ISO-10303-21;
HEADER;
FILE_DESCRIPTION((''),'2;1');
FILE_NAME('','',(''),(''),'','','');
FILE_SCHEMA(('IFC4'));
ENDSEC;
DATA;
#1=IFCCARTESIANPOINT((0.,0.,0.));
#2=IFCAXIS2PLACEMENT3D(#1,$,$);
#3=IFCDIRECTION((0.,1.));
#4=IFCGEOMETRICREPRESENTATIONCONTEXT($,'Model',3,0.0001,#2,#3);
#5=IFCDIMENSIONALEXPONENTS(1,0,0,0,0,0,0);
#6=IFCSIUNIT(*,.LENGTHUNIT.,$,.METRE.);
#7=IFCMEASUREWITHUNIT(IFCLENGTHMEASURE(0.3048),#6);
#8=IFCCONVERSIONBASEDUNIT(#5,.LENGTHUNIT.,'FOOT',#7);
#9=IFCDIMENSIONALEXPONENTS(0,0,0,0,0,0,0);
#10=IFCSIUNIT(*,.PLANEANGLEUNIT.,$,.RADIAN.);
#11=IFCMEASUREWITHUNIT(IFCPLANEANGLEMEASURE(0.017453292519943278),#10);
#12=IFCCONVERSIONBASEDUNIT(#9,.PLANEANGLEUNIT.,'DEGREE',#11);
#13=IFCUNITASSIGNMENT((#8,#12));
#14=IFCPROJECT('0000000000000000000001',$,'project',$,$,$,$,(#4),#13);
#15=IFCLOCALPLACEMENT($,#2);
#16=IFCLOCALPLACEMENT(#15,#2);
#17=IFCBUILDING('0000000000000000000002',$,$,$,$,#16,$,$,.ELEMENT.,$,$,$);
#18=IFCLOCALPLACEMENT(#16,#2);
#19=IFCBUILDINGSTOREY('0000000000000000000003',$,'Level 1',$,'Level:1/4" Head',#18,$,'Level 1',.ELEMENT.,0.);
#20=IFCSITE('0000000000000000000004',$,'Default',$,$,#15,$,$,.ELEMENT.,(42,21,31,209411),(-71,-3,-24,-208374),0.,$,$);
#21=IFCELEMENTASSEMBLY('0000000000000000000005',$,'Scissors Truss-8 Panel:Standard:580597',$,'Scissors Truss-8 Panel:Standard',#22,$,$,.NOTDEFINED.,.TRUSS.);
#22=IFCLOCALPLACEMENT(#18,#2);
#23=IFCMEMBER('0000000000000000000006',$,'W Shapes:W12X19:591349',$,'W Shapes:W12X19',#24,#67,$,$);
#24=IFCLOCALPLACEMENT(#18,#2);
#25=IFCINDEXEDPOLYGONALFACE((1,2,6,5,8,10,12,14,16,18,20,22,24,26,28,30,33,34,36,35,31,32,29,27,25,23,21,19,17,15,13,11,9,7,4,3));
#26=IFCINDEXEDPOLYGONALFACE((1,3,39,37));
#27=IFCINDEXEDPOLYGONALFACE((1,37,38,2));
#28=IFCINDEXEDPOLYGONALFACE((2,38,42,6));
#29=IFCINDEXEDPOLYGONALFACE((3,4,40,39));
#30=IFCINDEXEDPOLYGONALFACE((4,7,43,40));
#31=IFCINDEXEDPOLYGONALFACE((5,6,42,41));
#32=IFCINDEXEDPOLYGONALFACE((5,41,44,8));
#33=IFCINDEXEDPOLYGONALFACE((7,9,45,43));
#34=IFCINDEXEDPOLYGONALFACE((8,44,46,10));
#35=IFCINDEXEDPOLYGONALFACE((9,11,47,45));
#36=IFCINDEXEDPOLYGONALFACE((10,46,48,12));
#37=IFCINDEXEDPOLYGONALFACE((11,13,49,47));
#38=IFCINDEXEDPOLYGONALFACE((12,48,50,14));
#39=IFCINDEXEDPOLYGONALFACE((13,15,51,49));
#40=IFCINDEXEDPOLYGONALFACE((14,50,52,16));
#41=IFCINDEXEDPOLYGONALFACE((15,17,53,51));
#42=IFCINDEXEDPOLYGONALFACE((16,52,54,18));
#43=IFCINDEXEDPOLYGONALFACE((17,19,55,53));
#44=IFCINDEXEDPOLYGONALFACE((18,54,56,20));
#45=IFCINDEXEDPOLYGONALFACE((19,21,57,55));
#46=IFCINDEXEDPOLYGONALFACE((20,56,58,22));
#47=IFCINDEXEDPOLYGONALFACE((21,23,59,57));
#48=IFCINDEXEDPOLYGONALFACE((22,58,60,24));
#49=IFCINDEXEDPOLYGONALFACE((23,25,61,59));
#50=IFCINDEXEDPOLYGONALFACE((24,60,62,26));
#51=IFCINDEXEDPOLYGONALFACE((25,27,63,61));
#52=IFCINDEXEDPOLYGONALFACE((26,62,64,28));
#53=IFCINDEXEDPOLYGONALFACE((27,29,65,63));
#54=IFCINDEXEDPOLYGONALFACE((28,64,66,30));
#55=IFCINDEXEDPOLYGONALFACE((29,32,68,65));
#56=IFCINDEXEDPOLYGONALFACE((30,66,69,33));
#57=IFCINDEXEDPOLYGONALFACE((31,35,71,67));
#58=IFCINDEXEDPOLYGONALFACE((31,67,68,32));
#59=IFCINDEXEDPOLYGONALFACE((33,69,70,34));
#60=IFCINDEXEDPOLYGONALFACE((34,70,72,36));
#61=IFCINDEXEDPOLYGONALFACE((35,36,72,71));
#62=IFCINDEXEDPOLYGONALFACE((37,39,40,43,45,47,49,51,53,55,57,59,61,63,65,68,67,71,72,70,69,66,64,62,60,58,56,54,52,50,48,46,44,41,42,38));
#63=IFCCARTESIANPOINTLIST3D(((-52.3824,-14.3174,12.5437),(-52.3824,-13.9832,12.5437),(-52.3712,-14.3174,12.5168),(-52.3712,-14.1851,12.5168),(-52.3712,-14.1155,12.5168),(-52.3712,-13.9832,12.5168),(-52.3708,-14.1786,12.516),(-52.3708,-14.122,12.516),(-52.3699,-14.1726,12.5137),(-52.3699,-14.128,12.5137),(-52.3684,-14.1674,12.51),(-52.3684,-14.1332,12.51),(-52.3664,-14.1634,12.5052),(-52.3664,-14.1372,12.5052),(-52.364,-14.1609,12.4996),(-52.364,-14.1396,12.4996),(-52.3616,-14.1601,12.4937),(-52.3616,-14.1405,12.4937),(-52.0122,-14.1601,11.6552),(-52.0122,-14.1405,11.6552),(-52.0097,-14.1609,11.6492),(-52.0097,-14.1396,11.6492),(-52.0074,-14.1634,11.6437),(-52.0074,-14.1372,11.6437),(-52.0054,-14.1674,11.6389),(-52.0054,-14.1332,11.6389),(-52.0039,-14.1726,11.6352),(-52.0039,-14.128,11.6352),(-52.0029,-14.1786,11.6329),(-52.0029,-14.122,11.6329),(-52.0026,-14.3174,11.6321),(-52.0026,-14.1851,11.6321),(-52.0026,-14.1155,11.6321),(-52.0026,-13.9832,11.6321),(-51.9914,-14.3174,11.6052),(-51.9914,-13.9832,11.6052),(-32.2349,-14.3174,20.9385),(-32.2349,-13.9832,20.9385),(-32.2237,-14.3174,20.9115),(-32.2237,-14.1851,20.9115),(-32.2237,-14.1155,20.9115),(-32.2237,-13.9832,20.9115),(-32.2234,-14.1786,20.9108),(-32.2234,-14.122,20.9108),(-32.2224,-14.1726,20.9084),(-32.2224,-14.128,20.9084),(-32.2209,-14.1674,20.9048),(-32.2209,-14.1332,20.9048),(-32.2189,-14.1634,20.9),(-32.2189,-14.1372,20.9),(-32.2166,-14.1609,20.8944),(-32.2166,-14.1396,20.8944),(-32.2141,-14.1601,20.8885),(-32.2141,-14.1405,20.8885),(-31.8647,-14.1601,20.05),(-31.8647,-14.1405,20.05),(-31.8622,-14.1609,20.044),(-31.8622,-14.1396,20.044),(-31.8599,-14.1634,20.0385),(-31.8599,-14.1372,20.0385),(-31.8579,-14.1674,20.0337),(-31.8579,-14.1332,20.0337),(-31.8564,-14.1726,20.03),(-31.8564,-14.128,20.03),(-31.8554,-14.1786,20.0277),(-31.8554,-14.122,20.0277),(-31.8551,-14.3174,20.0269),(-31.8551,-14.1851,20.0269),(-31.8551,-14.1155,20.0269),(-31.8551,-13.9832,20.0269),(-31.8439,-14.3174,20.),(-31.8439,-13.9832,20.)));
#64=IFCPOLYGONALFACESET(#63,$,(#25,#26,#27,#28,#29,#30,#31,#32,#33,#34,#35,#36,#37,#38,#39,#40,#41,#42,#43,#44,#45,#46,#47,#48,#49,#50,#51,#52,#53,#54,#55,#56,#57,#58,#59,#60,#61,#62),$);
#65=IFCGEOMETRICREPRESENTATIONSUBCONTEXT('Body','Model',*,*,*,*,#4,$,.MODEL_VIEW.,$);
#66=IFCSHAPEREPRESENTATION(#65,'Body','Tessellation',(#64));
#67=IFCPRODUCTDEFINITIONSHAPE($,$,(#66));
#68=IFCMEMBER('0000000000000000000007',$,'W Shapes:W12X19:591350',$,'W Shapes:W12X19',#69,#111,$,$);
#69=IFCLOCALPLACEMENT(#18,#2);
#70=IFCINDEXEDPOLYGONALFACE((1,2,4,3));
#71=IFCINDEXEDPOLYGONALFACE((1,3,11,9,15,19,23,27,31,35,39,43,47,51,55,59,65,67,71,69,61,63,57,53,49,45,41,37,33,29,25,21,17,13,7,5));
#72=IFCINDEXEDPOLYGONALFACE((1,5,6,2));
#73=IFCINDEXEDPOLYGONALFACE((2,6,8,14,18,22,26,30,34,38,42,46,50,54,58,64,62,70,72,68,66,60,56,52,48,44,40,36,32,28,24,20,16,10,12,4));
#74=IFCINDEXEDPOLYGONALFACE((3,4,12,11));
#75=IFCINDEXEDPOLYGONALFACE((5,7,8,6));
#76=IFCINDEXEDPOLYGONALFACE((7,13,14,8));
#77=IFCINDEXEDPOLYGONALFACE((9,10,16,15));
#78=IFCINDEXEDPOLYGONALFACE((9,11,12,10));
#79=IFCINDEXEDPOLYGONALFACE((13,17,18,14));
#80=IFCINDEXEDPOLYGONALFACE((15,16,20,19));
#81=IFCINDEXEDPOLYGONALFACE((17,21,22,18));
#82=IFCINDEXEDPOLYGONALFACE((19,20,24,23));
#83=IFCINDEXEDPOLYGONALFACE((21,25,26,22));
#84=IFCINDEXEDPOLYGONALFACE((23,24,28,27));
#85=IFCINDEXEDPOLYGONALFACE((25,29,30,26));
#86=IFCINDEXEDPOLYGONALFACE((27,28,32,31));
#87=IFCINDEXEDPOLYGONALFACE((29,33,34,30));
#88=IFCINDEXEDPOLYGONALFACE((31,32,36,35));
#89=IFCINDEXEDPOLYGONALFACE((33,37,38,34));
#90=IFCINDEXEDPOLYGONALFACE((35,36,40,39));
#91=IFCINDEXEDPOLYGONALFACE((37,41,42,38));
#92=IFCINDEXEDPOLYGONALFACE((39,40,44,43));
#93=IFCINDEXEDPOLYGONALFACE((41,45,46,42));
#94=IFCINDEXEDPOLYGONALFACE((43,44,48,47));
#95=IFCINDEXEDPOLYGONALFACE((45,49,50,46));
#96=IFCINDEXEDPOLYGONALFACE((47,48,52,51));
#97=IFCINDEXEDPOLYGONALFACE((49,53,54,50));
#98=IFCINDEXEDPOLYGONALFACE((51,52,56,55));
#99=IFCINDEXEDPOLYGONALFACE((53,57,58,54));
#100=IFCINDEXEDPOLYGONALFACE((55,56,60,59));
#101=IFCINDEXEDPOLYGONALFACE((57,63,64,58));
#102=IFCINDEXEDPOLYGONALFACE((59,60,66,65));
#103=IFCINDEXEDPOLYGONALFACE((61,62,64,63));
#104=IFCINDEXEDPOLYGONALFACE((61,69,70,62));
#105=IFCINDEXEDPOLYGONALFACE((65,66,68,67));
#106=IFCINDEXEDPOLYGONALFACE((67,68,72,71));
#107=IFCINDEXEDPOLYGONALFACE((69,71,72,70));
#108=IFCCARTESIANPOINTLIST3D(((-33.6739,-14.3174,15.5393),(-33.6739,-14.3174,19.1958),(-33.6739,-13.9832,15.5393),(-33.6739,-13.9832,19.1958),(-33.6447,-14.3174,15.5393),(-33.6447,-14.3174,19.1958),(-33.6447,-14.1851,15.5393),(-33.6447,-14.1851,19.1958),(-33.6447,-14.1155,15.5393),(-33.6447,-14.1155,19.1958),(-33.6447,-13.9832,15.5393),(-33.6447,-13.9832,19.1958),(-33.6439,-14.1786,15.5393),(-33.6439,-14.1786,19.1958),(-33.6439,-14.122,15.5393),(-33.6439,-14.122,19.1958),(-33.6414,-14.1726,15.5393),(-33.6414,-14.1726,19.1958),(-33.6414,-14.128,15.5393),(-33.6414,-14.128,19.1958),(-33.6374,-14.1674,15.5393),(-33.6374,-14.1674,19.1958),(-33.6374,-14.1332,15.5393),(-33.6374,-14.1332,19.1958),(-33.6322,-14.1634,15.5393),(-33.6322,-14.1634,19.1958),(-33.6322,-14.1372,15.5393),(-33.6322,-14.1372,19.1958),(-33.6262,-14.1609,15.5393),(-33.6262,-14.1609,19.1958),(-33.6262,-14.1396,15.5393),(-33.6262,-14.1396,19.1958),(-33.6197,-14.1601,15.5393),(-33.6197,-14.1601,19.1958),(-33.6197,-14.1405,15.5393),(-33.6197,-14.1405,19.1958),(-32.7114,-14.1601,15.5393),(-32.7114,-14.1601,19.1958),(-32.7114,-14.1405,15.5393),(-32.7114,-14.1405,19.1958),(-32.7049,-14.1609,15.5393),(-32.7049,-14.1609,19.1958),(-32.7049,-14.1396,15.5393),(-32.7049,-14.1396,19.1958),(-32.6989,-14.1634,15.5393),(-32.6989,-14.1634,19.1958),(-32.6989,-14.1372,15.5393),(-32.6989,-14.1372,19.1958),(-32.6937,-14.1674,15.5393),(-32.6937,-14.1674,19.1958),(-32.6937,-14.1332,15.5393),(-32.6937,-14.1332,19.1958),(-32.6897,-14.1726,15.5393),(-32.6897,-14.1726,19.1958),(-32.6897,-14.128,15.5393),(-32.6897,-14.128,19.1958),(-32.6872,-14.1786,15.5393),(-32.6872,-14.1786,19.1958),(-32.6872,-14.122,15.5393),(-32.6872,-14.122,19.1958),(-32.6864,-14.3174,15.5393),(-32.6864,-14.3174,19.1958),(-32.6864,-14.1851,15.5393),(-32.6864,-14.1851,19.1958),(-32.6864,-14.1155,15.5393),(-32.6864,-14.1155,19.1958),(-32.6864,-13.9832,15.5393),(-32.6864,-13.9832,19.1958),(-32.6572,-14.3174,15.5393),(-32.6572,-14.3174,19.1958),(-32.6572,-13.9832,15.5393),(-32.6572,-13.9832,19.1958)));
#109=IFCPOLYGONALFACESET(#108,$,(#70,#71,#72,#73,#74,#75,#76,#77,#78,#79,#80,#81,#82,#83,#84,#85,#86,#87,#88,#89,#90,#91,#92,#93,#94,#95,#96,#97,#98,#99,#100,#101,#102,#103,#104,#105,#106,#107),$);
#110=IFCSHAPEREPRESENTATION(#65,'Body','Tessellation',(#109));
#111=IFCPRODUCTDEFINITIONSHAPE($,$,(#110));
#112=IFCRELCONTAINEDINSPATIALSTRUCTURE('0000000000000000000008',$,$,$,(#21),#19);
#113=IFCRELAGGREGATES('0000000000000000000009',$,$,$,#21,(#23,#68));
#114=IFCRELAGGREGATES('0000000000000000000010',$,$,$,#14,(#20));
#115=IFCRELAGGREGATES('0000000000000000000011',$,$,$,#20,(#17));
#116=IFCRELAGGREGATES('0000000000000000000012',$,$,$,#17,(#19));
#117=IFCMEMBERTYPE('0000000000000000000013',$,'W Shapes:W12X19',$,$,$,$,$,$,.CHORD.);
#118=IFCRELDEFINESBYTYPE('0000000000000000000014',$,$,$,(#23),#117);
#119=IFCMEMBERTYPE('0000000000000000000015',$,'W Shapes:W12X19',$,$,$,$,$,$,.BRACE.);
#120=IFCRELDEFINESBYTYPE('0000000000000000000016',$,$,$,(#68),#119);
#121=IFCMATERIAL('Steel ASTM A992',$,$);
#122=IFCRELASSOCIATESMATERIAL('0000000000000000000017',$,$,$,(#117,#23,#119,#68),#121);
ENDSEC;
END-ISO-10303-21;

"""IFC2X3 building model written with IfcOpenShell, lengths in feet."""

from ifc_helpers import new_model, entity, si_unit, converted_unit, direction, frame, frame_2d, origin, place, context, subcontext, project, spatial, polyline, circle_curve, parameter, trimmed, segment, composite_curve, outline, extrude, source, transform, mapped, material, type_object, type_shapes, element, aggregate, save


model = new_model("IFC2X3")

# Units and contexts
model_context = context("Model", 3, precision=0.0001, world=origin(), true_north=direction((0.0, 1.0)))
body_context = subcontext(model_context, "Body", "Model", "MODEL_VIEW")
ifc_project = project(units=[converted_unit("LENGTHUNIT", "FOOT", entity("IfcLengthMeasure", 0.3048), si_unit("LENGTHUNIT", "METRE"), dimensions=[1, 0, 0, 0, 0, 0, 0]), converted_unit("PLANEANGLEUNIT", "DEGREE", entity("IfcPlaneAngleMeasure", 0.017453292519943278), si_unit("PLANEANGLEUNIT", "RADIAN"), dimensions=[0, 0, 0, 0, 0, 0, 0])], contexts=[model_context])

# Site, building, storey
site_placement = place(None, origin())
site = spatial("IfcSite", under=ifc_project, at=site_placement, Name="Default", CompositionType="ELEMENT", RefLatitude=(42, 21, 31, 209411), RefLongitude=(-71, -3, -24, -208374), RefElevation=0.0)
building_placement = place(site_placement, origin())
building = spatial("IfcBuilding", under=site, at=building_placement, CompositionType="ELEMENT")
storey_placement = place(building_placement, origin())
storey = spatial("IfcBuildingStorey", under=building, at=storey_placement, Name="Level 1", ObjectType="Level:1/4\" Head", LongName="Level 1", CompositionType="ELEMENT", Elevation=0.0)

# Element assembly, members
assembly_placement = place(storey_placement, origin())
assembly = element("IfcElementAssembly", 1, at=assembly_placement, inside=storey, Name="Scissors Truss-8 Panel:Standard:580597", ObjectType="Scissors Truss-8 Panel:Standard", AssemblyPlace="NOTDEFINED", PredefinedType="TRUSS")
ifc_material = material(Name="Steel ASTM A992")
member_type_1 = type_object("IfcMemberType", Name="W Shapes:W12X19", PredefinedType="CHORD", material=ifc_material)
shared_shape_1 = source(origin(), body_context, "Body", "SweptSolid", [
    extrude(outline(composite_curve([segment(polyline([(-0.1671, -0.4792), (-0.1671, -0.5083)]), True, "CONTINUOUS"), segment(polyline([(-0.1671, -0.5083), (0.1671, -0.5083)]), True, "CONTINUOUS"), segment(polyline([(0.1671, -0.5083), (0.1671, -0.4792)]), True, "CONTINUOUS"), segment(polyline([(0.1671, -0.4792), (0.0348, -0.4792)]), True, "CONTINUOUS"), segment(trimmed(circle_curve(frame_2d((0.0348, -0.4542), x_axis=(1.0, 0.0)), 0.025), [parameter(180.0)], [parameter(270.0)], True, "PARAMETER"), False, "CONTINUOUS"), segment(polyline([(0.0098, -0.4542), (0.0098, 0.4542)]), True, "CONTINUOUS"), segment(trimmed(circle_curve(frame_2d((0.0348, 0.4542), x_axis=(1.0, 0.0)), 0.025), [parameter(90.0)], [parameter(180.0)], True, "PARAMETER"), False, "CONTINUOUS"), segment(polyline([(0.0348, 0.4792), (0.1671, 0.4792)]), True, "CONTINUOUS"), segment(polyline([(0.1671, 0.4792), (0.1671, 0.5083)]), True, "CONTINUOUS"), segment(polyline([(0.1671, 0.5083), (-0.1671, 0.5083)]), True, "CONTINUOUS"), segment(polyline([(-0.1671, 0.5083), (-0.1671, 0.4792)]), True, "CONTINUOUS"), segment(polyline([(-0.1671, 0.4792), (-0.0348, 0.4792)]), True, "CONTINUOUS"), segment(trimmed(circle_curve(frame_2d((-0.0348, 0.4542), x_axis=(1.0, 0.0)), 0.025), [parameter(360.0)], [parameter(90.0)], True, "PARAMETER"), False, "CONTINUOUS"), segment(polyline([(-0.0098, 0.4542), (-0.0098, -0.4542)]), True, "CONTINUOUS"), segment(trimmed(circle_curve(frame_2d((-0.0348, -0.4542), x_axis=(1.0, 0.0)), 0.025), [parameter(270.0)], [parameter(360.0)], True, "PARAMETER"), False, "CONTINUOUS"), segment(polyline([(-0.0348, -0.4792), (-0.1671, -0.4792)]), True, "CONTINUOUS")], self_intersect=False)), frame((-7.6064, 0.0, 0.0), z_axis=(-1.0, 0.0, 0.0), x_axis=(0.0, -1.0, 0.0)), (0.0, 0.0, -1.0), 21.8264),
])
type_shapes(member_type_1, [shared_shape_1])
member_1_placement = place(assembly_placement, frame((-45.1655, -14.1503, 15.0), z_axis=(-0.384615, 0.0, 0.923077), x_axis=(0.923077, 0.0, 0.384615)))
member_1 = element("IfcMember", 2, at=member_1_placement, type_object=member_type_1, material=ifc_material, Name="W Shapes:W12X19:591349", ObjectType="W Shapes:W12X19", context=body_context, shape_type="MappedRepresentation", body=[
    mapped(shared_shape_1, transform((0.0, 0.0, 0.0), scale=1.0)),
])
member_type_2 = type_object("IfcMemberType", Name="W Shapes:W12X19", PredefinedType="BRACE", material=ifc_material)
shared_shape_2 = source(origin(), body_context, "Body", "SweptSolid", [
    extrude(outline(composite_curve([segment(polyline([(-0.1671, -0.4792), (-0.1671, -0.5083)]), True, "CONTINUOUS"), segment(polyline([(-0.1671, -0.5083), (0.1671, -0.5083)]), True, "CONTINUOUS"), segment(polyline([(0.1671, -0.5083), (0.1671, -0.4792)]), True, "CONTINUOUS"), segment(polyline([(0.1671, -0.4792), (0.0348, -0.4792)]), True, "CONTINUOUS"), segment(trimmed(circle_curve(frame_2d((0.0348, -0.4542), x_axis=(1.0, 0.0)), 0.025), [parameter(180.0)], [parameter(270.0)], True, "PARAMETER"), False, "CONTINUOUS"), segment(polyline([(0.0098, -0.4542), (0.0098, 0.4542)]), True, "CONTINUOUS"), segment(trimmed(circle_curve(frame_2d((0.0348, 0.4542), x_axis=(1.0, 0.0)), 0.025), [parameter(90.0)], [parameter(180.0)], True, "PARAMETER"), False, "CONTINUOUS"), segment(polyline([(0.0348, 0.4792), (0.1671, 0.4792)]), True, "CONTINUOUS"), segment(polyline([(0.1671, 0.4792), (0.1671, 0.5083)]), True, "CONTINUOUS"), segment(polyline([(0.1671, 0.5083), (-0.1671, 0.5083)]), True, "CONTINUOUS"), segment(polyline([(-0.1671, 0.5083), (-0.1671, 0.4792)]), True, "CONTINUOUS"), segment(polyline([(-0.1671, 0.4792), (-0.0348, 0.4792)]), True, "CONTINUOUS"), segment(trimmed(circle_curve(frame_2d((-0.0348, 0.4542), x_axis=(1.0, 0.0)), 0.025), [parameter(360.0)], [parameter(90.0)], True, "PARAMETER"), False, "CONTINUOUS"), segment(polyline([(-0.0098, 0.4542), (-0.0098, -0.4542)]), True, "CONTINUOUS"), segment(trimmed(circle_curve(frame_2d((-0.0348, -0.4542), x_axis=(1.0, 0.0)), 0.025), [parameter(270.0)], [parameter(360.0)], True, "PARAMETER"), False, "CONTINUOUS"), segment(polyline([(-0.0348, -0.4792), (-0.1671, -0.4792)]), True, "CONTINUOUS")], self_intersect=False)), frame((-1.9607, 0.0, 0.0), z_axis=(-1.0, 0.0, 0.0), x_axis=(0.0, -1.0, 0.0)), (0.0, 0.0, -1.0), 3.6565),
])
type_shapes(member_type_2, [shared_shape_2])
member_2_placement = place(assembly_placement, frame((-33.1655, -14.1503, 17.5), z_axis=(1.0, 0.0, 0.0), x_axis=(0.0, 0.0, 1.0)))
member_2 = element("IfcMember", 3, at=member_2_placement, type_object=member_type_2, material=ifc_material, Name="W Shapes:W12X19:591350", ObjectType="W Shapes:W12X19", context=body_context, shape_type="MappedRepresentation", body=[
    mapped(shared_shape_2, transform((0.0, 0.0, 0.0), scale=1.0)),
])
aggregate(assembly, [member_1, member_2])

save(model, "model.ifc")
